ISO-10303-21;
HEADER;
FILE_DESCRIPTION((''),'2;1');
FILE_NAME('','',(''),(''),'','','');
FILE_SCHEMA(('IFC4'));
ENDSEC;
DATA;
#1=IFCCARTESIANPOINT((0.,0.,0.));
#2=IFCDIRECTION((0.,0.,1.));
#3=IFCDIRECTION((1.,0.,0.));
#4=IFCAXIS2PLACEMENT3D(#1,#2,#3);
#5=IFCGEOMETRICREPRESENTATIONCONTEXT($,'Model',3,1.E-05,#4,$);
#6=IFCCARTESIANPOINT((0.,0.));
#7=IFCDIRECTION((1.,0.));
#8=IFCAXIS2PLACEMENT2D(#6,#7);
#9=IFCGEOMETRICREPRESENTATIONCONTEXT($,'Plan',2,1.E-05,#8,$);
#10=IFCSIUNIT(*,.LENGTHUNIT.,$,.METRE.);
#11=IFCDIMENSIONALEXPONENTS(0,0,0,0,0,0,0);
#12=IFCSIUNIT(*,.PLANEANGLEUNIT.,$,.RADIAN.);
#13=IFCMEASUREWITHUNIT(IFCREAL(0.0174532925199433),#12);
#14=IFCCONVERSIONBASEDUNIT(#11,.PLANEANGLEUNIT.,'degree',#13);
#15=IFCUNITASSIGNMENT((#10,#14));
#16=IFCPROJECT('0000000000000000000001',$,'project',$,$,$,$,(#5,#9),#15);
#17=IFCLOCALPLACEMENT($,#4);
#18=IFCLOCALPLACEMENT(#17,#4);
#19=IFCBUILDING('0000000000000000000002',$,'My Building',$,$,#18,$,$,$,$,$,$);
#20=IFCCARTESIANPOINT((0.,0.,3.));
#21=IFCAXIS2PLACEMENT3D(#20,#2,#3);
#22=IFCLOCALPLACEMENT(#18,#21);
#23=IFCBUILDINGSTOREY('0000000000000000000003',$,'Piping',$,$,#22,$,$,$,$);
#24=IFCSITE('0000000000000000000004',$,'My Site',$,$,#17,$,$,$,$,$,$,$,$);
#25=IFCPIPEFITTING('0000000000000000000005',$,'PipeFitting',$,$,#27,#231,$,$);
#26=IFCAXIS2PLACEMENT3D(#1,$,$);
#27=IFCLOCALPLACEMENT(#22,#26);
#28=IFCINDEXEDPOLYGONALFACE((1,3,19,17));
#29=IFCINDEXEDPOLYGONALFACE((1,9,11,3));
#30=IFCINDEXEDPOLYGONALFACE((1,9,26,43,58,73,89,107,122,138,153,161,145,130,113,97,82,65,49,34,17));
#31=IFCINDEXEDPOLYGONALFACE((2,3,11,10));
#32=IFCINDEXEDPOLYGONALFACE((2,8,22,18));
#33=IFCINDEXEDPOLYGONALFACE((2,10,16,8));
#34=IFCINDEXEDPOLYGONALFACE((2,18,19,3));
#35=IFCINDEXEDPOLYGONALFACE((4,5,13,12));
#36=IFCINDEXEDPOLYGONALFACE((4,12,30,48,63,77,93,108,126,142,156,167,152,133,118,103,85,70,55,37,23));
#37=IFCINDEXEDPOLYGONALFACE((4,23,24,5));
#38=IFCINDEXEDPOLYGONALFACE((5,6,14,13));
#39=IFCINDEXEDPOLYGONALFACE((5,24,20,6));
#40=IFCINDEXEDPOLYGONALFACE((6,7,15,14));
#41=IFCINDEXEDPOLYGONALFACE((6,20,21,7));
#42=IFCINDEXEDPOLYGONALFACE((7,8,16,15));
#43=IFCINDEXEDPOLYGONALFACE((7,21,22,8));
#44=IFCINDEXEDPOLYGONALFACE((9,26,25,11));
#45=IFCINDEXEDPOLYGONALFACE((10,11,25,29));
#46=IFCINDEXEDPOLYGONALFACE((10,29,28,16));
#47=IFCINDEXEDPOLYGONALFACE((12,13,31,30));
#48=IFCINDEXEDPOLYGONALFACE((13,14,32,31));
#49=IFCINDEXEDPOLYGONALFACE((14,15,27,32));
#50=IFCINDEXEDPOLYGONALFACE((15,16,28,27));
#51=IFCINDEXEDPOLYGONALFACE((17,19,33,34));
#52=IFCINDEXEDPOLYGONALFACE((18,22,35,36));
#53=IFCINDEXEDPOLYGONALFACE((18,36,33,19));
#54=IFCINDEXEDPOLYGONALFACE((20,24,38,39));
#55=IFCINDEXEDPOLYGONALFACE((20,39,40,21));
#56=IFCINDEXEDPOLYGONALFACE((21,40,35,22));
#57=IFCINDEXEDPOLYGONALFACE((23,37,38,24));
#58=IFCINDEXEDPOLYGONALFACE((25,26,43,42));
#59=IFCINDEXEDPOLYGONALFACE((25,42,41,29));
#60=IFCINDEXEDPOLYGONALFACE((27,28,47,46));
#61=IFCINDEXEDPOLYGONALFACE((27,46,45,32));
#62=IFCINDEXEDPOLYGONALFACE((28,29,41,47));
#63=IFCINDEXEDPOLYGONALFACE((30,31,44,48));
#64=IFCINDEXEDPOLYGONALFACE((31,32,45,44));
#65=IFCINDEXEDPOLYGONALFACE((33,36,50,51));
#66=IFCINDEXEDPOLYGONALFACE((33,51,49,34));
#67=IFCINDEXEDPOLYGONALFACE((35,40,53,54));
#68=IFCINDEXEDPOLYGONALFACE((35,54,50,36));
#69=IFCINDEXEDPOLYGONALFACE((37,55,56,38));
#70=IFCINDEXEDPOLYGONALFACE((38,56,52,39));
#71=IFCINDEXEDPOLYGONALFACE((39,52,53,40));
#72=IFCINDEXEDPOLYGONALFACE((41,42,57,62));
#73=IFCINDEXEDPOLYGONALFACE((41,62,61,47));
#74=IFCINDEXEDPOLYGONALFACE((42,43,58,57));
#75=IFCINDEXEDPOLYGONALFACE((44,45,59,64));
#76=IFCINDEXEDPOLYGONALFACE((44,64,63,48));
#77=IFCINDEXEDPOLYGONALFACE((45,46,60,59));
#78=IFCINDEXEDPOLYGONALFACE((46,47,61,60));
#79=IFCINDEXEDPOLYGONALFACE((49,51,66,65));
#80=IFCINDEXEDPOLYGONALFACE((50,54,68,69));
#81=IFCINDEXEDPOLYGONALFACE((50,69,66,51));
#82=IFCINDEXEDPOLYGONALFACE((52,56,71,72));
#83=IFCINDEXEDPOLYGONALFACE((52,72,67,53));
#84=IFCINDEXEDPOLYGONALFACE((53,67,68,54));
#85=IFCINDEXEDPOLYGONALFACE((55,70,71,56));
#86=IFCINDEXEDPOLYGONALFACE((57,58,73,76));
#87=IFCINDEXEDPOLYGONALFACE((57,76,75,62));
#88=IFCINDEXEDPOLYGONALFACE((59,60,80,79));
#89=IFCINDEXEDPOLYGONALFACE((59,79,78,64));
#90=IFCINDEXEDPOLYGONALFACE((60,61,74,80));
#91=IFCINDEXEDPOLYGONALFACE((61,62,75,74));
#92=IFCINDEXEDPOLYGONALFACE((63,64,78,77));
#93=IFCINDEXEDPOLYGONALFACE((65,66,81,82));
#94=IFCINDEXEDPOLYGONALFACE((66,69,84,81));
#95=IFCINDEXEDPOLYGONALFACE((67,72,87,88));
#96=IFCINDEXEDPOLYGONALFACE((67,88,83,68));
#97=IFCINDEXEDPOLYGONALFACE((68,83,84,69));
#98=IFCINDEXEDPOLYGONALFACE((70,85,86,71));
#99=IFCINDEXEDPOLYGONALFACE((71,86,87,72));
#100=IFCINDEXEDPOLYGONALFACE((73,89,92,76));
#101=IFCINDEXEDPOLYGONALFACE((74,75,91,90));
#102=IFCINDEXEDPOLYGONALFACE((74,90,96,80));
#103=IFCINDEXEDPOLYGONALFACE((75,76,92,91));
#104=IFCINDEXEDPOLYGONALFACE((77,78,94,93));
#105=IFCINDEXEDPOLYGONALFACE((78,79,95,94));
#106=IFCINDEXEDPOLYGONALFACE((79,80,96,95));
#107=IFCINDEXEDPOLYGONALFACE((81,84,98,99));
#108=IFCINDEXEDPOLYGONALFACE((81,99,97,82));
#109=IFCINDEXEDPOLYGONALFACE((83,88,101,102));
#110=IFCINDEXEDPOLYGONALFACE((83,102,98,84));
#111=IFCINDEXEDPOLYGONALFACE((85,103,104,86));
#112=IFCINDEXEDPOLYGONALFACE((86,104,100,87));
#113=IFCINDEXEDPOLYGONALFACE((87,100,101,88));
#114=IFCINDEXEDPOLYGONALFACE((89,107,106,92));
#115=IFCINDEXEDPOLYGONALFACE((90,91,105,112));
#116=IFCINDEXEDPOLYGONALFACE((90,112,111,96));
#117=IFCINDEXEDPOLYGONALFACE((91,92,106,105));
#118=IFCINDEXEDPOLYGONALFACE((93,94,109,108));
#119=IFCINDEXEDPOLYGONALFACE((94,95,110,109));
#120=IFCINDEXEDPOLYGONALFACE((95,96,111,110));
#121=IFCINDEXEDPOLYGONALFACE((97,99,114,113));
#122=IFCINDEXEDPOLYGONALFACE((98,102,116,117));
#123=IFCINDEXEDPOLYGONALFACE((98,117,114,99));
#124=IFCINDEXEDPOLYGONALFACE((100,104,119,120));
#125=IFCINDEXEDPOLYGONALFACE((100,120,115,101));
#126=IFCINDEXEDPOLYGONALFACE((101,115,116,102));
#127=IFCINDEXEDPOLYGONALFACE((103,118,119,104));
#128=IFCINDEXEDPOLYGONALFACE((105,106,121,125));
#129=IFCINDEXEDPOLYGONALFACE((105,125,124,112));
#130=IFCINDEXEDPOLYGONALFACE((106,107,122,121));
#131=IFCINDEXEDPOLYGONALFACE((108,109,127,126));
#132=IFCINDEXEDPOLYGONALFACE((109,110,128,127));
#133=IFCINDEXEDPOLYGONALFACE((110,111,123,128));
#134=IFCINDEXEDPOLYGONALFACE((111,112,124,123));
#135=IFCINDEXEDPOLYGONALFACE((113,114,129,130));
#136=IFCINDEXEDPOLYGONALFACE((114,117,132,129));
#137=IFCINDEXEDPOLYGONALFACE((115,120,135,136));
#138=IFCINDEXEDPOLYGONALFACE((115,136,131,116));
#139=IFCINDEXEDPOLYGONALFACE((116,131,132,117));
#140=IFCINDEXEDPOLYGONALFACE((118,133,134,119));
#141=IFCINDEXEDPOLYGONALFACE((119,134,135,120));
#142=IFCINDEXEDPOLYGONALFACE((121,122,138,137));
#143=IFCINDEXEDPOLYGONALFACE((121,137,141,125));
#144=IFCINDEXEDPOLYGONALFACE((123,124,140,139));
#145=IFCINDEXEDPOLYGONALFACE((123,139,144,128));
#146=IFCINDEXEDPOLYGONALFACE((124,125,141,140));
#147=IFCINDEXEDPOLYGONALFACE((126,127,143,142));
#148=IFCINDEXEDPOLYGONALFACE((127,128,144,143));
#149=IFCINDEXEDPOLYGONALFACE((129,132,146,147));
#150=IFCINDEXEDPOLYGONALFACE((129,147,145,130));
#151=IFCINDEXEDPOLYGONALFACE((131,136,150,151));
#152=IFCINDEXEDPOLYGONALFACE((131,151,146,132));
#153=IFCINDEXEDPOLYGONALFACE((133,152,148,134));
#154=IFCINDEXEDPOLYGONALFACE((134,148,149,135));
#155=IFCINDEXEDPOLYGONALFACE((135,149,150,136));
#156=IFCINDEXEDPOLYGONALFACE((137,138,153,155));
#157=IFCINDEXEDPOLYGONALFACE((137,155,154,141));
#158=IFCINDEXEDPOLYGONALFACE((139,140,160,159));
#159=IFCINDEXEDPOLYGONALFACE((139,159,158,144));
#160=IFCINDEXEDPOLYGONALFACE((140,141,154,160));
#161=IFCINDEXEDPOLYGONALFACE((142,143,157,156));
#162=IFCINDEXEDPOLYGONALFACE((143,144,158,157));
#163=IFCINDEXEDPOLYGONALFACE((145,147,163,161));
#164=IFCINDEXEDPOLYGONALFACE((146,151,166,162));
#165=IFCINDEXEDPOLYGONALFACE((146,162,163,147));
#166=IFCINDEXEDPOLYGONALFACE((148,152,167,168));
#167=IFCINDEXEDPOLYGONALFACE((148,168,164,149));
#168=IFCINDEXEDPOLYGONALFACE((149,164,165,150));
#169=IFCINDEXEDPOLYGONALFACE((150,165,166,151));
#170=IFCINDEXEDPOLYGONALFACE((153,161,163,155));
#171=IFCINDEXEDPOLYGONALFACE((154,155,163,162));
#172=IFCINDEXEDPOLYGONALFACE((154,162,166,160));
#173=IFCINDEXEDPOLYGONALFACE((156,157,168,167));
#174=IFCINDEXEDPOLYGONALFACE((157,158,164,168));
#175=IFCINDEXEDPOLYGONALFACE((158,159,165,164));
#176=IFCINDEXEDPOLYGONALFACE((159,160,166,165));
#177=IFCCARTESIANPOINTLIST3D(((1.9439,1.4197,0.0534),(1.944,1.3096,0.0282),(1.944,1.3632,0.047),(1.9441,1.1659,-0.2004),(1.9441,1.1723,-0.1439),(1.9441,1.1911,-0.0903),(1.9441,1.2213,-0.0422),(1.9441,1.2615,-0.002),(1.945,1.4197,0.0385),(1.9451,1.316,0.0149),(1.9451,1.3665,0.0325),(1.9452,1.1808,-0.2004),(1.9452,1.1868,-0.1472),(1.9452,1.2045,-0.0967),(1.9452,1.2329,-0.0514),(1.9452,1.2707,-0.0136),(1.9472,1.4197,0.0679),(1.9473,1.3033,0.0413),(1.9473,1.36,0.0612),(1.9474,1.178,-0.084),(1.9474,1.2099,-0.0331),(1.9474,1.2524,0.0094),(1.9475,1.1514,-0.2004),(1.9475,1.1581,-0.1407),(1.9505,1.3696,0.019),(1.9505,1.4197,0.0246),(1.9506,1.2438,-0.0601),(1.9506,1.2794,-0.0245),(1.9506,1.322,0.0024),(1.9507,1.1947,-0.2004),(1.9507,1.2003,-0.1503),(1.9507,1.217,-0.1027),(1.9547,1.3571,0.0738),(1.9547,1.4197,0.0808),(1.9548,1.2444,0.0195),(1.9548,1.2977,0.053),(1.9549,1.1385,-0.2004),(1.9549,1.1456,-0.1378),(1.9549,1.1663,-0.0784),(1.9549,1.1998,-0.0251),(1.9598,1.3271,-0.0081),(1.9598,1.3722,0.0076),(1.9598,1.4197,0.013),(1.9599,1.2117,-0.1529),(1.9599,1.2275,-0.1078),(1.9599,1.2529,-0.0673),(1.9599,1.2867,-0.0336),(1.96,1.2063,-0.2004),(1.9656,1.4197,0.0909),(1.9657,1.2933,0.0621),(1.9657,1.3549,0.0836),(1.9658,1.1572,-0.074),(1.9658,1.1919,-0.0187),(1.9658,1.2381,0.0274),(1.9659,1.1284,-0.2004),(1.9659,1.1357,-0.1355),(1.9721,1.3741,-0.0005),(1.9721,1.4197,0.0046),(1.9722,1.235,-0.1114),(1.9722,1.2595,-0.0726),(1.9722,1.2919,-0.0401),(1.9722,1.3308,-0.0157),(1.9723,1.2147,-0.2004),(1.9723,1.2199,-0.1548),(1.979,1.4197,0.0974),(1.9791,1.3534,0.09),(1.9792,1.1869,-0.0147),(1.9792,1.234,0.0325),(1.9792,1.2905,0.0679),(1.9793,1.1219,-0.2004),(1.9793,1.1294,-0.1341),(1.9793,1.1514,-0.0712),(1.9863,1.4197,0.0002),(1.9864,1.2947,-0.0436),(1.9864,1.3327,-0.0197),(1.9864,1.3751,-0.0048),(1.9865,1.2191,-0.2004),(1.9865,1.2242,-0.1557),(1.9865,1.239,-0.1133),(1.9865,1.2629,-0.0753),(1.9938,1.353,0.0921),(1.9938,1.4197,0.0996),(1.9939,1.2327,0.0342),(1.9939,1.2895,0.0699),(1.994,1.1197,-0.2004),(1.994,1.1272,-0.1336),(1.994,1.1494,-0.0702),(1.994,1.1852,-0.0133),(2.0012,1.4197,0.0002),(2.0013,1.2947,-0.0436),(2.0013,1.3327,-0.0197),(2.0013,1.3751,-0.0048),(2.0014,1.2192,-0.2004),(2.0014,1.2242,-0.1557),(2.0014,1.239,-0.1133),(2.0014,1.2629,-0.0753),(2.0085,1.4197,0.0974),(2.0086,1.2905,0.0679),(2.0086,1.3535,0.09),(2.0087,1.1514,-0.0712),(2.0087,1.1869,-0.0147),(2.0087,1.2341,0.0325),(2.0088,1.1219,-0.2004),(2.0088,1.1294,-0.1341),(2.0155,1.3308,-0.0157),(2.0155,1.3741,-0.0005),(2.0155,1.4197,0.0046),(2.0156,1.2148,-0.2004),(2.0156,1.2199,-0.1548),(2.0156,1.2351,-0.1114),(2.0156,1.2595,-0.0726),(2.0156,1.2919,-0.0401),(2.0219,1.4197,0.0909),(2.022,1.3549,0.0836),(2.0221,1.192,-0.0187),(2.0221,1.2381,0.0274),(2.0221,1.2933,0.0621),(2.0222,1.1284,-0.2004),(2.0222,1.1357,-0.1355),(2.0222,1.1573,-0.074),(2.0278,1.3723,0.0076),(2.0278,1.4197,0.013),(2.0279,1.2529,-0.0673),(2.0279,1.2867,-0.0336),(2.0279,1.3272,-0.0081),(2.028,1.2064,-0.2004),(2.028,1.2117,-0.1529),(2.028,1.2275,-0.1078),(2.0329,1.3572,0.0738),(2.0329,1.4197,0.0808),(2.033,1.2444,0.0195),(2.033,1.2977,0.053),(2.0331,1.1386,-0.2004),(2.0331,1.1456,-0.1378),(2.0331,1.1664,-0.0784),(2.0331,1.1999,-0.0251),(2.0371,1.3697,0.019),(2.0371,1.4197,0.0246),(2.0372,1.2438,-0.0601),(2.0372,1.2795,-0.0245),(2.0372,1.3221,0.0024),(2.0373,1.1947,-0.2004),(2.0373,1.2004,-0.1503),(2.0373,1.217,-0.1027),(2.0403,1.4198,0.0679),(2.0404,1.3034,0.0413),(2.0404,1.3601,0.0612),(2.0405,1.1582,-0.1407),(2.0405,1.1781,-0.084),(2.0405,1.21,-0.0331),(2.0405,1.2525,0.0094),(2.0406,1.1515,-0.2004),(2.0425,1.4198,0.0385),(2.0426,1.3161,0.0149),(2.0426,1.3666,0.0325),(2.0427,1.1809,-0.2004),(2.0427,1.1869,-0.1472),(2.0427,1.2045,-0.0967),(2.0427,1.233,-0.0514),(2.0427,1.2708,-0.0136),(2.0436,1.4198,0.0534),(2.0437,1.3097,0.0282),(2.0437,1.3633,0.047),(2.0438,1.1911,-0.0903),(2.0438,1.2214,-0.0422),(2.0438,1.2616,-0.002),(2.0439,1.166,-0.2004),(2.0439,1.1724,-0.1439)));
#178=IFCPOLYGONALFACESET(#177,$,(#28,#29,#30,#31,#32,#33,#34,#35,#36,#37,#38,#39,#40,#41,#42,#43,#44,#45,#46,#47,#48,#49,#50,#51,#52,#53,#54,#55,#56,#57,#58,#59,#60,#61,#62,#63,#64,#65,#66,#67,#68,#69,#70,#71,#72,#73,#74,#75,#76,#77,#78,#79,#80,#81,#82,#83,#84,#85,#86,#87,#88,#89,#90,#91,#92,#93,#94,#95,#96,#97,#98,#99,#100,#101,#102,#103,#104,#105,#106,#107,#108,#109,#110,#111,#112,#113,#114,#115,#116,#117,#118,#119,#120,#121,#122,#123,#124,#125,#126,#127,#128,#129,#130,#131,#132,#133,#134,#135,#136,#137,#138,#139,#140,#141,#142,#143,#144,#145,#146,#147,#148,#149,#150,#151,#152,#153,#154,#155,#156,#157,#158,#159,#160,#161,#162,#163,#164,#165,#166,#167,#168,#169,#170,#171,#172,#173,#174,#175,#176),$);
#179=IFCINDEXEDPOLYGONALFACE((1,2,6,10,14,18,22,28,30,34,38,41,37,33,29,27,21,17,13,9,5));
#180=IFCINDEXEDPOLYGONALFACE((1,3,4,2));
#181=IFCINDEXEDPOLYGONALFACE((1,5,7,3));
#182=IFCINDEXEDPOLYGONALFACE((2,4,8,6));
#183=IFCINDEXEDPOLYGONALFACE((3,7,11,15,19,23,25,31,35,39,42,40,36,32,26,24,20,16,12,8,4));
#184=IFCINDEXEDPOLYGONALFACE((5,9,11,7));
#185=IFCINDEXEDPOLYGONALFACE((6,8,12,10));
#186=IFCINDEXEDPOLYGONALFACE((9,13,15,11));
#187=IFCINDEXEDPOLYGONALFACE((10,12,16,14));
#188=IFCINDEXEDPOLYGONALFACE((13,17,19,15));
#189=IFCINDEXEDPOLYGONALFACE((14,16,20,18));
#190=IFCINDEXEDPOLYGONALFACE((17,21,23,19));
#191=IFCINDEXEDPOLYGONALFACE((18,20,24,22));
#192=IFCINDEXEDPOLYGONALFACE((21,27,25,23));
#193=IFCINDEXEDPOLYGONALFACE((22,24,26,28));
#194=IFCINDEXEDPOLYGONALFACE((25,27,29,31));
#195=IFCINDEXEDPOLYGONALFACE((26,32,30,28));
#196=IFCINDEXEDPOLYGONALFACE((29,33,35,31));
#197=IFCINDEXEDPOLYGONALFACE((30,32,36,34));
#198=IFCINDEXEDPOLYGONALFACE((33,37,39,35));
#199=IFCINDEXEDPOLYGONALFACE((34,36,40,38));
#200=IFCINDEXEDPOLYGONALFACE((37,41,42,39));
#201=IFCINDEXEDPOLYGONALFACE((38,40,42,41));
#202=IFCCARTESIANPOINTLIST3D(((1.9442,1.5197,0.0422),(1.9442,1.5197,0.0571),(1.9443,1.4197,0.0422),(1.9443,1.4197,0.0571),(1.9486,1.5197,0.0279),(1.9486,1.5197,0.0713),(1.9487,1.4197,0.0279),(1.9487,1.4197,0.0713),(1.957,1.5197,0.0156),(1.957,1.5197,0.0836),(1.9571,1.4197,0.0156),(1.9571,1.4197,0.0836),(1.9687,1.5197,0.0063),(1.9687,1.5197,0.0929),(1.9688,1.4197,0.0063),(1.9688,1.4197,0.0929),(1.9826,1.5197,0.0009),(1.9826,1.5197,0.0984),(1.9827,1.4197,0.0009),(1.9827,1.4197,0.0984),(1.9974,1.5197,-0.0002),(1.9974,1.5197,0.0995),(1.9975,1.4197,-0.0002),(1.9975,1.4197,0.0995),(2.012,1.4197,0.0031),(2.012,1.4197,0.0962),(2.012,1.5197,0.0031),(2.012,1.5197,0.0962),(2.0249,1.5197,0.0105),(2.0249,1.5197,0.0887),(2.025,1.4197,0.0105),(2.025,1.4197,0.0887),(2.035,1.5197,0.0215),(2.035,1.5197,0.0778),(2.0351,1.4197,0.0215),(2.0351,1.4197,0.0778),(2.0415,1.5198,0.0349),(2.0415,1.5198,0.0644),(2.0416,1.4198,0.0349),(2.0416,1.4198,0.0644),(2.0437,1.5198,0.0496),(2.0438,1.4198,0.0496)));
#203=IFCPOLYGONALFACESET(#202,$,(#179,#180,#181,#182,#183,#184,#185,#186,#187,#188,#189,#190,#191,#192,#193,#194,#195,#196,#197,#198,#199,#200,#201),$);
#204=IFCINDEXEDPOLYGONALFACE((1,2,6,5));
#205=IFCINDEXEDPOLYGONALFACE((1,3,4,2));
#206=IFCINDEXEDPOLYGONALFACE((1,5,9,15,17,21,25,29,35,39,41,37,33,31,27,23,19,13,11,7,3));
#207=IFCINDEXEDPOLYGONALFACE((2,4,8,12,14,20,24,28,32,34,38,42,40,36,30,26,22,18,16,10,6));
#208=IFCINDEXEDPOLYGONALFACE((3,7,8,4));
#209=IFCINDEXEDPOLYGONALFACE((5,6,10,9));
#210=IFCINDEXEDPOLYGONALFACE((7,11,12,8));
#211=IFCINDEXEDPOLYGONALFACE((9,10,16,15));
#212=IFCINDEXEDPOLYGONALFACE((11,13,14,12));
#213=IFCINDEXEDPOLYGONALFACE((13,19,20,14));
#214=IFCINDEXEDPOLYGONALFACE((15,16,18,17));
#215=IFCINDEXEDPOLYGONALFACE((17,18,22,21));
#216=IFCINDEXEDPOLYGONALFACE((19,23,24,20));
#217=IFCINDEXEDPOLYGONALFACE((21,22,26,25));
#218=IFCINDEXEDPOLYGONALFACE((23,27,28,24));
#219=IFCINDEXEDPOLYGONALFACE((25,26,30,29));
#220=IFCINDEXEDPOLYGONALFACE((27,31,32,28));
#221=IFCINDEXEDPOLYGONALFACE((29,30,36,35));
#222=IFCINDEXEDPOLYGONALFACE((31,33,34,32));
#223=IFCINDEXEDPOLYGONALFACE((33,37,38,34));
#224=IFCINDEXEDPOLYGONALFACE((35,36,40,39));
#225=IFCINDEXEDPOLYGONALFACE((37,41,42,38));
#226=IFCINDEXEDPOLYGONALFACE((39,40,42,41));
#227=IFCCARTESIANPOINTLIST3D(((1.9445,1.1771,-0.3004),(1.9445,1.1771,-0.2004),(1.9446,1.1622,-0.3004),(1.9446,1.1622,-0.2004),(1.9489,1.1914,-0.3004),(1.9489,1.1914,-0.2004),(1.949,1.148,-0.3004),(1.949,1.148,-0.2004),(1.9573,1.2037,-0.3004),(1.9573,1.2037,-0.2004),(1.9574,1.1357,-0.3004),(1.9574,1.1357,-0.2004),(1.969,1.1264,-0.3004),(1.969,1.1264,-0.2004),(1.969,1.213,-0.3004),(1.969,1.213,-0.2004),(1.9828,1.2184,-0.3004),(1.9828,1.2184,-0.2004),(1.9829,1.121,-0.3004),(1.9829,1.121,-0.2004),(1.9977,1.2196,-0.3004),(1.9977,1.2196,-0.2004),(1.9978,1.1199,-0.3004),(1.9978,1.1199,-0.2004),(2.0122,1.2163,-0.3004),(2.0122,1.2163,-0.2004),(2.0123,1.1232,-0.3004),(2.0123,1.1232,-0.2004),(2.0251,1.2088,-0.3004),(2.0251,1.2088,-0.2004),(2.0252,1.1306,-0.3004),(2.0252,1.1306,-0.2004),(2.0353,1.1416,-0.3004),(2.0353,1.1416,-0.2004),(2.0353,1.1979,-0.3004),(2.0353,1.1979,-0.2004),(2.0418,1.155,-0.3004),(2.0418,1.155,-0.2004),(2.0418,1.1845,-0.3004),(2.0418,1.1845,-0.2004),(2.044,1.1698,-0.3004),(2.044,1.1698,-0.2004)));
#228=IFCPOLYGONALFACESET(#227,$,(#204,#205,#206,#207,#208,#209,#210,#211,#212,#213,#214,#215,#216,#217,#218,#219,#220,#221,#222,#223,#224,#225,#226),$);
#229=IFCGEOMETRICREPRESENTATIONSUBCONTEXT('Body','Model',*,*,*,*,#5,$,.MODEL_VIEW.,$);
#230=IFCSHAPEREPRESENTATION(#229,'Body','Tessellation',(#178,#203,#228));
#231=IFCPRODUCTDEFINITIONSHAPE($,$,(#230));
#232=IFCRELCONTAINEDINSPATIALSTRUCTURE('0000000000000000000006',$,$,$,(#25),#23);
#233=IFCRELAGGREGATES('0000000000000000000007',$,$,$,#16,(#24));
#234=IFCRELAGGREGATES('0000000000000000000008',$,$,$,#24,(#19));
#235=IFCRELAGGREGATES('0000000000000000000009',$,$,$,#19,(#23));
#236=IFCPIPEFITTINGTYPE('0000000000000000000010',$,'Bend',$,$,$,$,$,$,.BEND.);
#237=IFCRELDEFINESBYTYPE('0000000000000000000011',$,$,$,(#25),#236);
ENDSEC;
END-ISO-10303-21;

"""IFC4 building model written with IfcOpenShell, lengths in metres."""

from ifc_helpers import new_model, entity, si_unit, converted_unit, frame, origin_with_axes, origin_2d_with_axis, place, context, subcontext, project, spatial, circle, extrude, source, transform, mapped, type_object, type_shapes, element, save


model = new_model("IFC4")

# Units and contexts
model_context = context("Model", 3, precision=1e-05, world=origin_with_axes())
plan_context = context("Plan", 2, precision=1e-05, world=origin_2d_with_axis())
body_context = subcontext(model_context, "Body", "Model", "MODEL_VIEW")
ifc_project = project(units=[si_unit("LENGTHUNIT", "METRE"), converted_unit("PLANEANGLEUNIT", "degree", entity("IfcReal", 0.0174532925199433), si_unit("PLANEANGLEUNIT", "RADIAN"), dimensions=[0, 0, 0, 0, 0, 0, 0])], contexts=[model_context, plan_context])

# Site, building, storey
site_placement = place(None, origin_with_axes())
site = spatial("IfcSite", under=ifc_project, at=site_placement, Name="My Site")
building_placement = place(site_placement, origin_with_axes())
building = spatial("IfcBuilding", under=site, at=building_placement, Name="My Building")
storey_placement = place(building_placement, frame((0.0, 0.0, 3.0), z_axis=(0.0, 0.0, 1.0), x_axis=(1.0, 0.0, 0.0)))
storey = spatial("IfcBuildingStorey", under=building, at=storey_placement, Name="Piping")

# Pipe fitting
pipe_fitting_type_1 = type_object("IfcPipeFittingType", Name="Bend", PredefinedType="BEND")
shared_shape = source(origin_with_axes(), body_context, "Body", "SolidModel", [
    entity("IfcSweptDiskSolid", entity("IfcIndexedPolyCurve", entity("IfcCartesianPointList3D", [[0.0, 0.0, 0.1], [0.0, -0.0732, 0.2768], [0.0, -0.25, 0.35]]), [entity("IfcArcIndex", [1, 2, 3])]), 0.05),
    extrude(circle(Radius=0.05), origin_with_axes(), (0.0, 0.0, 1.0), 0.1),
    extrude(circle(Radius=0.05), frame((0.0, -0.25, 0.35), z_axis=(0.0, -1.0, -0.000001), x_axis=(1.0, 0.0, 0.0)), (0.0, 0.0, 1.0), 0.1),
])
type_shapes(pipe_fitting_type_1, [shared_shape])
for number, where, z_axis, x_axis, name in (
    (1, (1.9937, 1.5197, 0.0496), (0.000872, -1.0, 0.000001), (1.0, 0.000872, 0.0), "PipeFitting"),
):
    element("IfcPipeFitting", number, at=place(storey_placement, frame(where, z_axis=z_axis, x_axis=x_axis)), inside=storey, type_object=pipe_fitting_type_1, Name=name, context=body_context, shape_type="MappedRepresentation", body=[
        mapped(shared_shape, transform((0.0, 0.0, 0.0), x_axis=(1.0, 0.0, 0.0), y_axis=(0.0, 1.0, 0.0), z_axis=(0.0, 0.0, 1.0), scale=1.0)),
    ])

save(model, "model.ifc")
